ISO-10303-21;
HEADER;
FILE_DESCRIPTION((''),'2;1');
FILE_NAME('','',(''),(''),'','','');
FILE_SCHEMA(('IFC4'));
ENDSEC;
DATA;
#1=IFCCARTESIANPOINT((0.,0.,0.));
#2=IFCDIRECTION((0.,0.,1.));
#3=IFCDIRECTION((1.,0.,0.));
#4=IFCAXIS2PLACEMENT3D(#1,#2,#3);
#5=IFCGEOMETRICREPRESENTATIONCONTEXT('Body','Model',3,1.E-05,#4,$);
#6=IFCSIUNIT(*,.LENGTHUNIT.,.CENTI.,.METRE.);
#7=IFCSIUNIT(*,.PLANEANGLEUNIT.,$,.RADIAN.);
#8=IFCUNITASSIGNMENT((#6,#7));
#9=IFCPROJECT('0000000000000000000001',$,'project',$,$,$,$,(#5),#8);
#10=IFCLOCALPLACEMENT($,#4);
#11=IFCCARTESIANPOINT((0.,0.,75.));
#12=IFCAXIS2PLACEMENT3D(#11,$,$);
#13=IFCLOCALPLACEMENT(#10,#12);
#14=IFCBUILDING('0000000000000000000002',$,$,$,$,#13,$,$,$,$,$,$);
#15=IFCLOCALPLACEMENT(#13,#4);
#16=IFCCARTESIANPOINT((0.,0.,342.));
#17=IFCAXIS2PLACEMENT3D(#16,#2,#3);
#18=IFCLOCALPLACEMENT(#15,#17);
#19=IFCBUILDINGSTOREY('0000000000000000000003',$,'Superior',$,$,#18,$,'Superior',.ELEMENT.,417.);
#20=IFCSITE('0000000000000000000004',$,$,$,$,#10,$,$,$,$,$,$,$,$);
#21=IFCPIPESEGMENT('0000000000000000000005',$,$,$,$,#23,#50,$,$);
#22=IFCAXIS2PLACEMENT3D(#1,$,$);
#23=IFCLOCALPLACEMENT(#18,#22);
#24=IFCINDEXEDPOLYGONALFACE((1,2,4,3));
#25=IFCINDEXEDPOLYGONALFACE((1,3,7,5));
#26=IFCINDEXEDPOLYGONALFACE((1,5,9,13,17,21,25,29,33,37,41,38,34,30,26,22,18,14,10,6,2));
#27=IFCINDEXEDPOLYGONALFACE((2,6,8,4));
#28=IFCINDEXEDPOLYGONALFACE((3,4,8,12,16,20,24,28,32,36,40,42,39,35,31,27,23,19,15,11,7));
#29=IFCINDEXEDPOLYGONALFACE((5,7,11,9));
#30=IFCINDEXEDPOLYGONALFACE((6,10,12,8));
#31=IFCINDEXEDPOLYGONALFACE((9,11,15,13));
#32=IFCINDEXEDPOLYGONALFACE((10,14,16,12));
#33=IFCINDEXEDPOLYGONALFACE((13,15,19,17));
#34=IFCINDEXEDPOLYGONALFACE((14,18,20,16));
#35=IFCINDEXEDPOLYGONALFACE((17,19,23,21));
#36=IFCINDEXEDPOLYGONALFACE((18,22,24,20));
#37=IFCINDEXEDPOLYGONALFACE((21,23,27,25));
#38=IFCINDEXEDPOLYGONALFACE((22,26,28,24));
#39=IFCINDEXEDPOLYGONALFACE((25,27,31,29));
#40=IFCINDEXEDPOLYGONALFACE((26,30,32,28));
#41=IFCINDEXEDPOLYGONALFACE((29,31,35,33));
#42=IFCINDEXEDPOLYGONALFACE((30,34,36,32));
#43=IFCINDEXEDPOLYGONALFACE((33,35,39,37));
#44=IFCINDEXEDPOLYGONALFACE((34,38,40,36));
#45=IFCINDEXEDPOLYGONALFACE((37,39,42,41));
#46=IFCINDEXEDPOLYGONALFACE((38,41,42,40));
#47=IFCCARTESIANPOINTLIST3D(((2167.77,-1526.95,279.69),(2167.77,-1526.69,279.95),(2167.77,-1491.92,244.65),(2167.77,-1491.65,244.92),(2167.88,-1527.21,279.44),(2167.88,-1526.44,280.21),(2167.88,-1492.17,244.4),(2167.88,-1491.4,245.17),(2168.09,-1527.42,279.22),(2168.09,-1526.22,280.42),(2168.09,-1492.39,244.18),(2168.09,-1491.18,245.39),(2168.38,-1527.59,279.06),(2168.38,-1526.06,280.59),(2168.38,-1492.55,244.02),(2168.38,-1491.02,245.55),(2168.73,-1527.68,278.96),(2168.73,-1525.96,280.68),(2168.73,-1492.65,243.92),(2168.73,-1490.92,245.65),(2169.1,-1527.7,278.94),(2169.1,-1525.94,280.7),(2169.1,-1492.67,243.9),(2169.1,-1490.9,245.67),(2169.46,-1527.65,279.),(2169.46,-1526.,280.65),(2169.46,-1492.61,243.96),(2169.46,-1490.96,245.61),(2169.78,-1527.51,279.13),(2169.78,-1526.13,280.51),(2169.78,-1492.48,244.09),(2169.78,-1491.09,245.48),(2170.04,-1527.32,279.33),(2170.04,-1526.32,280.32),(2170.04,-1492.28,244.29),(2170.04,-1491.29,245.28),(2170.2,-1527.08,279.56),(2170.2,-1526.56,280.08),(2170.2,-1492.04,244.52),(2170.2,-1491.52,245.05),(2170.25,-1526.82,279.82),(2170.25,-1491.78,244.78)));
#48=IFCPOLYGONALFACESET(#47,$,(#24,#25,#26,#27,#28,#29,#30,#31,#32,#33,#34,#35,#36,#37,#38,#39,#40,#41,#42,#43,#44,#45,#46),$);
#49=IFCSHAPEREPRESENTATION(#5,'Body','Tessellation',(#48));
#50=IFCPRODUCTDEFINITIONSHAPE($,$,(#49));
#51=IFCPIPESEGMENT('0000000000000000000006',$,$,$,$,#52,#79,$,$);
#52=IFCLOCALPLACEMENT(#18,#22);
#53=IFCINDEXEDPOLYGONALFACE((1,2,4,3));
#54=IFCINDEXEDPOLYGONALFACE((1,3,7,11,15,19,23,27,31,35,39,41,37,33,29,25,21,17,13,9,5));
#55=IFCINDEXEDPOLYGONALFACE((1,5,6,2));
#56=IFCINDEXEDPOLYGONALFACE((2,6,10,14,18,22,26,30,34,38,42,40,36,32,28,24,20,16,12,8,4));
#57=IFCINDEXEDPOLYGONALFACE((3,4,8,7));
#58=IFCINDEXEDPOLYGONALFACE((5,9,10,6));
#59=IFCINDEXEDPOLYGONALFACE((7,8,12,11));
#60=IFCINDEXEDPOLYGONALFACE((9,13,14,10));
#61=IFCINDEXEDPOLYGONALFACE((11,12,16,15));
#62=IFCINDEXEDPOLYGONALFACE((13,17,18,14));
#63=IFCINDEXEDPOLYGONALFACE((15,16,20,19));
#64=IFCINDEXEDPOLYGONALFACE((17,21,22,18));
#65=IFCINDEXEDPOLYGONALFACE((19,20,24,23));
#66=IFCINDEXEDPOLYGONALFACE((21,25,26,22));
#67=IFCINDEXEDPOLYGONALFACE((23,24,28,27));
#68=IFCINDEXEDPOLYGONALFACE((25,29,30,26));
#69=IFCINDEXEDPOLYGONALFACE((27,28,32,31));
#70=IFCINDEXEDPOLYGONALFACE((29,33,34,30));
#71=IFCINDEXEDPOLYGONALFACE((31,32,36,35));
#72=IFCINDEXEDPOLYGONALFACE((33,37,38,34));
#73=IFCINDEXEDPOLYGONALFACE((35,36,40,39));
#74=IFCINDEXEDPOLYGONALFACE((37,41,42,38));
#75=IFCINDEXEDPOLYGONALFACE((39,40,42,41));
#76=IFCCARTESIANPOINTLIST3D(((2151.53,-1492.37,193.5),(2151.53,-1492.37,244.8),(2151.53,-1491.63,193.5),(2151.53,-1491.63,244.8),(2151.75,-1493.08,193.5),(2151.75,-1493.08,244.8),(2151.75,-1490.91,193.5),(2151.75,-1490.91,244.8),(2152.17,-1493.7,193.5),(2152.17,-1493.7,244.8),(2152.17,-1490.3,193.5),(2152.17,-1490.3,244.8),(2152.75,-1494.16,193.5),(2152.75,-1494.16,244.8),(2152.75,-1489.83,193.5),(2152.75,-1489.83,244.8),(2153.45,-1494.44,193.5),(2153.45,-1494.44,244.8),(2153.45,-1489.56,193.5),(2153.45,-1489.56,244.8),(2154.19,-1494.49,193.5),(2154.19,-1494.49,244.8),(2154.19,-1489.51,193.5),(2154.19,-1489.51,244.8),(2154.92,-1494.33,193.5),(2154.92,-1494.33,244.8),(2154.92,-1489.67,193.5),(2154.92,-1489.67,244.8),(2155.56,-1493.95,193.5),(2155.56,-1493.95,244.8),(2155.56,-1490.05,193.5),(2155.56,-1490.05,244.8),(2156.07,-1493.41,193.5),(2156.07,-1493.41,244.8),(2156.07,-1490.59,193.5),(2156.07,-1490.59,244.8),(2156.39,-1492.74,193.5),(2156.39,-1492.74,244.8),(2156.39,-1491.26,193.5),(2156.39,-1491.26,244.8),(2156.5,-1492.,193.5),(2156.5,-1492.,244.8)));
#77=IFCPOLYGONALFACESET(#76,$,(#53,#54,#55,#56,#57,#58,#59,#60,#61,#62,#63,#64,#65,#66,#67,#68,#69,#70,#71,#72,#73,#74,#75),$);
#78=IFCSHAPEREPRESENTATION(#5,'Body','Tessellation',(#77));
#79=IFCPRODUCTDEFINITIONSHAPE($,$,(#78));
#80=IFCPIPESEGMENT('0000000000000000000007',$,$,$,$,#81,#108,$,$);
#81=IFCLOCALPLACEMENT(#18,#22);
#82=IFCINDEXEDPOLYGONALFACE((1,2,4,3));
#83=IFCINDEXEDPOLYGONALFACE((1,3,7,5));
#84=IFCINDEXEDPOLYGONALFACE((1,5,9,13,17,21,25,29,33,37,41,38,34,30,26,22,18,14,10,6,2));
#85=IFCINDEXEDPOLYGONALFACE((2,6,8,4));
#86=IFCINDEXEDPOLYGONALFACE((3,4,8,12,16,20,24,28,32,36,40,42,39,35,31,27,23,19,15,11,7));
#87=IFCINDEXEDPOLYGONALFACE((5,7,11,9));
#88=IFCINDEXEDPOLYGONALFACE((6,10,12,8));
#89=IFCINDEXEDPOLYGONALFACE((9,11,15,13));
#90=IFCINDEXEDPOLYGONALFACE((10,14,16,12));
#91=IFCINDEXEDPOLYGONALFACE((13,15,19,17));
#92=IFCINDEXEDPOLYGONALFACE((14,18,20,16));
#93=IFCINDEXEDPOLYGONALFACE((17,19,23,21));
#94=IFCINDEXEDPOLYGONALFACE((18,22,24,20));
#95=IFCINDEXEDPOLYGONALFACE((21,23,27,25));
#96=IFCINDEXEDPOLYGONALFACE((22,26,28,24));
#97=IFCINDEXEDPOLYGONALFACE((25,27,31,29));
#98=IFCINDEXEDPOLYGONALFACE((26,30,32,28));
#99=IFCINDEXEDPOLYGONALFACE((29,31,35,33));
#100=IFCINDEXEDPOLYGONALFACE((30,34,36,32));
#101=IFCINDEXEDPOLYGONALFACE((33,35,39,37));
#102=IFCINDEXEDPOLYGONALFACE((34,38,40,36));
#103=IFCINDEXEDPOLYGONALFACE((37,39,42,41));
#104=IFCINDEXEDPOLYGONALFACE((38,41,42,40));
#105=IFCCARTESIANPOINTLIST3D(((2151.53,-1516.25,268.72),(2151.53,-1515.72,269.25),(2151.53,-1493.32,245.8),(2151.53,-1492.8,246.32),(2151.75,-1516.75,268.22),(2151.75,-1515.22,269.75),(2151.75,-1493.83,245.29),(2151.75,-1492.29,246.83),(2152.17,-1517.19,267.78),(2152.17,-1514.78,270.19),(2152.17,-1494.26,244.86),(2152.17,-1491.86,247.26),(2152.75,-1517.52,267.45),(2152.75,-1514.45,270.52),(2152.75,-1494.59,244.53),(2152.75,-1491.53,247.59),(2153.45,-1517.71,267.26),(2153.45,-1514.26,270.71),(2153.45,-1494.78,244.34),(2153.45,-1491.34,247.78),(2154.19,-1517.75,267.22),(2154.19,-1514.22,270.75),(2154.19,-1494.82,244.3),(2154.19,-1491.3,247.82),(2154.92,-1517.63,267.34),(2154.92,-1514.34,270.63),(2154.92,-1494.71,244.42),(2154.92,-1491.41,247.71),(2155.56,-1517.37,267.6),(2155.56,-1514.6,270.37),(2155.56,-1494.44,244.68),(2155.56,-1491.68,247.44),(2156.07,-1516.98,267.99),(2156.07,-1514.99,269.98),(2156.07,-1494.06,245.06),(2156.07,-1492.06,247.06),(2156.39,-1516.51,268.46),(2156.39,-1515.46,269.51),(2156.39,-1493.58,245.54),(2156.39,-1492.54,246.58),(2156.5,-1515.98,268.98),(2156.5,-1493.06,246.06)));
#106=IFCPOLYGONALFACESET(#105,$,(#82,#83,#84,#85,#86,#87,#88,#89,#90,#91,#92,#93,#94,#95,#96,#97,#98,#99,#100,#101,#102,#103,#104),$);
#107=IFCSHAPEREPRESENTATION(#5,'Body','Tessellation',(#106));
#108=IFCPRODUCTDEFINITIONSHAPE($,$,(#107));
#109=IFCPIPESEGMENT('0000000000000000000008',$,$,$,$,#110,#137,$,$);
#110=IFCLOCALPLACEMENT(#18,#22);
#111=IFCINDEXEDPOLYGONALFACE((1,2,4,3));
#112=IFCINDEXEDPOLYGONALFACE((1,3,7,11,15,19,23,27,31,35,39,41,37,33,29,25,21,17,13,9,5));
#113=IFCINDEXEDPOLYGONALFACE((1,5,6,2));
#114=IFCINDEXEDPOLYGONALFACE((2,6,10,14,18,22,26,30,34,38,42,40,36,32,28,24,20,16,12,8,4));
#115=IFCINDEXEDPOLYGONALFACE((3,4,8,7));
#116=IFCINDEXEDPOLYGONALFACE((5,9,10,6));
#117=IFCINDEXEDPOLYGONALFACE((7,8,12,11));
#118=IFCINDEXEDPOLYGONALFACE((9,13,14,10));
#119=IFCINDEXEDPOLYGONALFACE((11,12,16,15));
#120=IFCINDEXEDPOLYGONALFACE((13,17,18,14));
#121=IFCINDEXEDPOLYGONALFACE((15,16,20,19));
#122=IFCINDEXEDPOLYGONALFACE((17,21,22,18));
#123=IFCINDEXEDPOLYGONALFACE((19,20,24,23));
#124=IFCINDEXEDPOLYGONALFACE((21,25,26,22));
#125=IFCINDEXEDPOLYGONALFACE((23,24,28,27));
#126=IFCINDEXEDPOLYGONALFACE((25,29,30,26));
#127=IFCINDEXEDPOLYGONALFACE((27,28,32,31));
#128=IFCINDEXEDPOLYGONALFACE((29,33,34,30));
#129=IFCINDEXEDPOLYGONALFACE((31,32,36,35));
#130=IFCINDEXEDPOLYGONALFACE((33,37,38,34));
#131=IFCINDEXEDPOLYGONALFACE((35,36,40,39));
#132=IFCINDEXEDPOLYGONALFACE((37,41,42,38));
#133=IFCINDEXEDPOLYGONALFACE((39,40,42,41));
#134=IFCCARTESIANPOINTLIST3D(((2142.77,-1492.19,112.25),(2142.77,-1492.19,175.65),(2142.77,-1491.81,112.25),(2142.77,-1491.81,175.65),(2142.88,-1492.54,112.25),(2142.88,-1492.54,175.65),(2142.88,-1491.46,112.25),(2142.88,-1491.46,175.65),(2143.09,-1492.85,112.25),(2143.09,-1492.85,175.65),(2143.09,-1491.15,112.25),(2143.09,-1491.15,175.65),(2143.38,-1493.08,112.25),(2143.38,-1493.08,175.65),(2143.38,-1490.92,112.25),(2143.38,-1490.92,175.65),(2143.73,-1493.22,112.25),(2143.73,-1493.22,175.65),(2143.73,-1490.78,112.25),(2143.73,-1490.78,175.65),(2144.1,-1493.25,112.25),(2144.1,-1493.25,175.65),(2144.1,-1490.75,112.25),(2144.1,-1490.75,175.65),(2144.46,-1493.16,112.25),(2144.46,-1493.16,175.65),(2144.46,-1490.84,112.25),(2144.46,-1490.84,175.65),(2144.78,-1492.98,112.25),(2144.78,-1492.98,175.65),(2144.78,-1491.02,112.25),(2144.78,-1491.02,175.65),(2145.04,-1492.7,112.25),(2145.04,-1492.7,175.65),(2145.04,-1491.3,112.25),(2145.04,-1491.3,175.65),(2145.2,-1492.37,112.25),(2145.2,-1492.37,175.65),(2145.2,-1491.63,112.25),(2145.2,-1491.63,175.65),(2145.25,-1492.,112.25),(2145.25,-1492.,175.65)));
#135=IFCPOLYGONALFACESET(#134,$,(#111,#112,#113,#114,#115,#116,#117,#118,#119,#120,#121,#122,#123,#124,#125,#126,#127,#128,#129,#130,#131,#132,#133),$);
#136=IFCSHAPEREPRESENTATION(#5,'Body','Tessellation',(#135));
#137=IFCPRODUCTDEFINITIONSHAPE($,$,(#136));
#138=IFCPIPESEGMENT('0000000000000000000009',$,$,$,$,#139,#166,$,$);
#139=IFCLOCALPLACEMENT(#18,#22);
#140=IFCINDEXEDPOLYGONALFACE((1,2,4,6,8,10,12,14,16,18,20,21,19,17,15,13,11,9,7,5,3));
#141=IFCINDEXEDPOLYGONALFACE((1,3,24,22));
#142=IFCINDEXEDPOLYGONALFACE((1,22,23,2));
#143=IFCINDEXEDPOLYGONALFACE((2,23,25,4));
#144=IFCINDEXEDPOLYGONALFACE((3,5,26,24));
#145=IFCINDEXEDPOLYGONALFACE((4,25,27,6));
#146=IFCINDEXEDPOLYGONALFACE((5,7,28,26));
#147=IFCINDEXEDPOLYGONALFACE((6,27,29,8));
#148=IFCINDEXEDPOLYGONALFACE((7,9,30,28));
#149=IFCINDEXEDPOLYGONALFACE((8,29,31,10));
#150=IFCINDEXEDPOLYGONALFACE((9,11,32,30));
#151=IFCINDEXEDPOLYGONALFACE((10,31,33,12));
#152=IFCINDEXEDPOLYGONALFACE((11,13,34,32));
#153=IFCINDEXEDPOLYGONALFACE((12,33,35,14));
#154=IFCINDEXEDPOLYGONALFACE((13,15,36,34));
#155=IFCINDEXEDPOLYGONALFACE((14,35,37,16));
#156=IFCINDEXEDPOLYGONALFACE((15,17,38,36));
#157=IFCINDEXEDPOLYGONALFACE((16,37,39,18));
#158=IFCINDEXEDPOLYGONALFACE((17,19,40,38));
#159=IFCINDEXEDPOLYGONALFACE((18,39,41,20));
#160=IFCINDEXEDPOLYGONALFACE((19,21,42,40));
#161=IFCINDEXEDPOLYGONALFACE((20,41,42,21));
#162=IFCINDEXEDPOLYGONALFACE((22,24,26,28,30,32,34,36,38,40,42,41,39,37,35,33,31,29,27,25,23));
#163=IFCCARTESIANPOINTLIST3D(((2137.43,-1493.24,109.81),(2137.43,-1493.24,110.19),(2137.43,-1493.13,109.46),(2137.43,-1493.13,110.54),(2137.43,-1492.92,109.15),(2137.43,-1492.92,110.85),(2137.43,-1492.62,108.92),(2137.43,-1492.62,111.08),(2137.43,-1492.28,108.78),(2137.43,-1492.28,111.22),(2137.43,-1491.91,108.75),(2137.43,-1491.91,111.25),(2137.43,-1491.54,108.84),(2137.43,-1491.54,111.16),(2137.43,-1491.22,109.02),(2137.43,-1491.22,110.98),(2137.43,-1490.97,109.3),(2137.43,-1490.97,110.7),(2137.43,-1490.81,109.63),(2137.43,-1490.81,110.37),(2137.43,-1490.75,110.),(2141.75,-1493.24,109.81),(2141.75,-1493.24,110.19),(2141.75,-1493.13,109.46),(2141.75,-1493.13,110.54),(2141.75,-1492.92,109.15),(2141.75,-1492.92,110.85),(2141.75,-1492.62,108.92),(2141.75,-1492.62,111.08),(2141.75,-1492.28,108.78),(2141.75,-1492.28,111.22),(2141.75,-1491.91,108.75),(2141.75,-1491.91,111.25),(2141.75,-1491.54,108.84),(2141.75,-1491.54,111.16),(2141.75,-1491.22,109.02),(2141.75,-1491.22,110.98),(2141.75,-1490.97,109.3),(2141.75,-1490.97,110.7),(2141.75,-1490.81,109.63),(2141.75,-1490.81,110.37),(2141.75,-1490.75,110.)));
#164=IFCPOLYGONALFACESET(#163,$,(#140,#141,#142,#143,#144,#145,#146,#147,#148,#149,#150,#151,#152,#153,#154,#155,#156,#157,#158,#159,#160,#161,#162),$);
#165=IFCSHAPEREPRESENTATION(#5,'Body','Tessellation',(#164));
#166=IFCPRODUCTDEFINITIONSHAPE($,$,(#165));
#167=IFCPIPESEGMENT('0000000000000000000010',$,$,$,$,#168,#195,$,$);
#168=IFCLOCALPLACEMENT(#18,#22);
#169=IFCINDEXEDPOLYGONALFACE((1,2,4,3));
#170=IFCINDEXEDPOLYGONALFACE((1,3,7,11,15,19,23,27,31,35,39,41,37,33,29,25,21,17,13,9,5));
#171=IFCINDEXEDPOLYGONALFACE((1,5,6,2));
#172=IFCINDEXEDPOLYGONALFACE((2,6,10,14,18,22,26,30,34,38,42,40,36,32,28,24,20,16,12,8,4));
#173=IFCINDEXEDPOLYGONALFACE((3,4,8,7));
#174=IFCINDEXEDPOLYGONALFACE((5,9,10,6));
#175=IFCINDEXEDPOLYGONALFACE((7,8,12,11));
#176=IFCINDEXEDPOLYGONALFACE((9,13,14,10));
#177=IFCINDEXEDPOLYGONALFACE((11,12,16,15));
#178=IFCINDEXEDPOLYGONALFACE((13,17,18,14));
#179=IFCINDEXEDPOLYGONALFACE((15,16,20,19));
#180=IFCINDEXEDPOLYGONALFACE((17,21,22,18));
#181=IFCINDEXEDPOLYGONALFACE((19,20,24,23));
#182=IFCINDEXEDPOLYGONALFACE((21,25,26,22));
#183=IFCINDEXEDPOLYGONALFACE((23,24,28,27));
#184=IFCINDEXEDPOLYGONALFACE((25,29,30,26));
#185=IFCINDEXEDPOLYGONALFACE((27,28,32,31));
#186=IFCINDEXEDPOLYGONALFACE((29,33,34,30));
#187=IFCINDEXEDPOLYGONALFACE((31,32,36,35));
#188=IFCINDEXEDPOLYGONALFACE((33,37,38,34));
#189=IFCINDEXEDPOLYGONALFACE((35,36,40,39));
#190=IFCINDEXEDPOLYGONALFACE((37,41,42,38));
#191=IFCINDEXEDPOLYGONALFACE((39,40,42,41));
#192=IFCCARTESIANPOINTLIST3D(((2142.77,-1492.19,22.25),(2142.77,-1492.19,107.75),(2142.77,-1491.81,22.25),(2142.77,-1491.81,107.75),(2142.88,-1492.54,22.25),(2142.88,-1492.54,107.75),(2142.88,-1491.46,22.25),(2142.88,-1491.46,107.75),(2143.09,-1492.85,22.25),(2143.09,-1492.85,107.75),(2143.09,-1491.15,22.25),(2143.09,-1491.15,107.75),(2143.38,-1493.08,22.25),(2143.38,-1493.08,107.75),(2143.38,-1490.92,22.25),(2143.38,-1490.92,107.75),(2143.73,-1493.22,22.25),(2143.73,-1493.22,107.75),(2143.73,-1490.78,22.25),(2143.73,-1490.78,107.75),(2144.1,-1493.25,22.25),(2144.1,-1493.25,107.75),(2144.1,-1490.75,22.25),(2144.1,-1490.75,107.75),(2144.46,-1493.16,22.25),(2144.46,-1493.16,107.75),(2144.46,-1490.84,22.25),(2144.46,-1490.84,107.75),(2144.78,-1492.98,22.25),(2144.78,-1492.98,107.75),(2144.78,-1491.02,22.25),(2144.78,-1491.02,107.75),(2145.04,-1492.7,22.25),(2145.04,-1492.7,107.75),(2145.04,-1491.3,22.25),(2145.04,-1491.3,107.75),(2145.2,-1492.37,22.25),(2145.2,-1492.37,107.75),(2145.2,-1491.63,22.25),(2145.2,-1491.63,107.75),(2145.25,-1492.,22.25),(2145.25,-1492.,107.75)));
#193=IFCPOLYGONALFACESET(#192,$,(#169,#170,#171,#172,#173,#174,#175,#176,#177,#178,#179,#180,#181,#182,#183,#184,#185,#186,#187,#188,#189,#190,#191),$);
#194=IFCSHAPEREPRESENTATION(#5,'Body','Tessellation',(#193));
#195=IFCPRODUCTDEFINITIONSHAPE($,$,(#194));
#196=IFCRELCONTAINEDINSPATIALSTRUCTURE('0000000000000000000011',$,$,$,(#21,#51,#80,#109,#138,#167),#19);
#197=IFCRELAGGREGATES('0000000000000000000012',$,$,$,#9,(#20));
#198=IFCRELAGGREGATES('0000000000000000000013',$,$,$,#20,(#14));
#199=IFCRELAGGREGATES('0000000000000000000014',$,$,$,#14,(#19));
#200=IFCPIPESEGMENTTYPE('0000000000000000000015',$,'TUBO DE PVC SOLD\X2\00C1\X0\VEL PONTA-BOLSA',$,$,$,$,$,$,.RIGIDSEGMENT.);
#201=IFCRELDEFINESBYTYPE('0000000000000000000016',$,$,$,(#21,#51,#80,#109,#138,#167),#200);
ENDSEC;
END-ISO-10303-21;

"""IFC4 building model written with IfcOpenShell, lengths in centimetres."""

from ifc_helpers import new_model, si_unit, frame, origin_with_axes, origin_2d_with_axis, place, context, project, spatial, circle, extrude, type_object, element, save


model = new_model("IFC4")

# Units and contexts
model_context = context("Model", 3, precision=1e-05, world=origin_with_axes(), identifier="Body")
ifc_project = project(units=[si_unit("LENGTHUNIT", "METRE", prefix="CENTI"), si_unit("PLANEANGLEUNIT", "RADIAN")], contexts=[model_context])

# Site, building, storey
site_placement = place(None, origin_with_axes())
site = spatial("IfcSite", under=ifc_project, at=site_placement)
building_placement = place(site_placement, frame((0.0, 0.0, 75.0)))
building = spatial("IfcBuilding", under=site, at=building_placement)
placement = place(building_placement, origin_with_axes())
storey_placement = place(placement, frame((0.0, 0.0, 342.0), z_axis=(0.0, 0.0, 1.0), x_axis=(1.0, 0.0, 0.0)))
storey = spatial("IfcBuildingStorey", under=building, at=storey_placement, Name="Superior", LongName="Superior", CompositionType="ELEMENT", Elevation=417.0)

# Pipe segments
pipe_segment_type_1 = type_object("IfcPipeSegmentType", Name="TUBO DE PVC SOLDÁVEL PONTA-BOLSA", PredefinedType="RIGIDSEGMENT")
pipe_segment_1_placement = place(storey_placement, frame((2169.0, -1509.3, 280.71), z_axis=(0.0, 0.0, 1.0), x_axis=(1.0, 0.0, 0.0)))
element("IfcPipeSegment", 1, at=pipe_segment_1_placement, inside=storey, type_object=pipe_segment_type_1, context=model_context, shape_type="SolidModel", body=[
    extrude(circle(Radius=1.25, at=origin_2d_with_axis()), frame((0.0, 17.52, -35.92), z_axis=(0.0, -0.707107, 0.707107), x_axis=(1.0, 0.0, 0.0)), (0.0, 0.0, 1.0), 49.55),
])
pipe_segment_2_placement = place(storey_placement, frame((2154.0, -1492.0, 244.8), z_axis=(0.0, 0.0, 1.0), x_axis=(1.0, 0.0, 0.0)))
element("IfcPipeSegment", 2, at=pipe_segment_2_placement, inside=storey, type_object=pipe_segment_type_1, context=model_context, shape_type="SolidModel", body=[
    extrude(circle(Radius=2.5, at=origin_2d_with_axis()), frame((0.0, 0.0, 0.0), z_axis=(0.0, 0.0, -1.0), x_axis=(1.0, 0.0, 0.0)), (0.0, 0.0, 1.0), 51.3),
])
pipe_segment_3_placement = place(storey_placement, frame((2154.0, -1504.52, 270.75), z_axis=(0.0, 0.0, 1.0), x_axis=(1.0, 0.0, 0.0)))
element("IfcPipeSegment", 3, at=pipe_segment_3_placement, inside=storey, type_object=pipe_segment_type_1, context=model_context, shape_type="SolidModel", body=[
    extrude(circle(Radius=2.5, at=origin_2d_with_axis()), frame((0.0, -11.46, -1.77), z_axis=(0.0, 0.707107, -0.707107), x_axis=(1.0, 0.0, 0.0)), (0.0, 0.0, 1.0), 32.42),
])
pipe_segment_4_placement = place(storey_placement, frame((2144.0, -1492.0, 175.65), z_axis=(0.0, 0.0, 1.0), x_axis=(1.0, 0.0, 0.0)))
element("IfcPipeSegment", 4, at=pipe_segment_4_placement, inside=storey, type_object=pipe_segment_type_1, context=model_context, shape_type="SolidModel", body=[
    extrude(circle(Radius=1.25, at=origin_2d_with_axis()), frame((0.0, 0.0, 0.0), z_axis=(0.0, 0.0, -1.0), x_axis=(1.0, 0.0, 0.0)), (0.0, 0.0, 1.0), 63.4),
])
pipe_segment_5_placement = place(storey_placement, frame((2139.59, -1492.0, 111.25), z_axis=(0.0, 0.0, 1.0), x_axis=(1.0, 0.0, 0.0)))
element("IfcPipeSegment", 5, at=pipe_segment_5_placement, inside=storey, type_object=pipe_segment_type_1, context=model_context, shape_type="SolidModel", body=[
    extrude(circle(Radius=1.25, at=origin_2d_with_axis()), frame((2.16, 0.0, -1.25), z_axis=(-1.0, 0.0, 0.0), x_axis=(0.0, 1.0, 0.0)), (0.0, 0.0, 1.0), 4.32),
])
pipe_segment_6_placement = place(storey_placement, frame((2144.0, -1492.0, 107.75), z_axis=(0.0, 0.0, 1.0), x_axis=(1.0, 0.0, 0.0)))
element("IfcPipeSegment", 6, at=pipe_segment_6_placement, inside=storey, type_object=pipe_segment_type_1, context=model_context, shape_type="SolidModel", body=[
    extrude(circle(Radius=1.25, at=origin_2d_with_axis()), frame((0.0, 0.0, 0.0), z_axis=(0.0, 0.0, -1.0), x_axis=(1.0, 0.0, 0.0)), (0.0, 0.0, 1.0), 85.5),
])

save(model, "model.ifc")
